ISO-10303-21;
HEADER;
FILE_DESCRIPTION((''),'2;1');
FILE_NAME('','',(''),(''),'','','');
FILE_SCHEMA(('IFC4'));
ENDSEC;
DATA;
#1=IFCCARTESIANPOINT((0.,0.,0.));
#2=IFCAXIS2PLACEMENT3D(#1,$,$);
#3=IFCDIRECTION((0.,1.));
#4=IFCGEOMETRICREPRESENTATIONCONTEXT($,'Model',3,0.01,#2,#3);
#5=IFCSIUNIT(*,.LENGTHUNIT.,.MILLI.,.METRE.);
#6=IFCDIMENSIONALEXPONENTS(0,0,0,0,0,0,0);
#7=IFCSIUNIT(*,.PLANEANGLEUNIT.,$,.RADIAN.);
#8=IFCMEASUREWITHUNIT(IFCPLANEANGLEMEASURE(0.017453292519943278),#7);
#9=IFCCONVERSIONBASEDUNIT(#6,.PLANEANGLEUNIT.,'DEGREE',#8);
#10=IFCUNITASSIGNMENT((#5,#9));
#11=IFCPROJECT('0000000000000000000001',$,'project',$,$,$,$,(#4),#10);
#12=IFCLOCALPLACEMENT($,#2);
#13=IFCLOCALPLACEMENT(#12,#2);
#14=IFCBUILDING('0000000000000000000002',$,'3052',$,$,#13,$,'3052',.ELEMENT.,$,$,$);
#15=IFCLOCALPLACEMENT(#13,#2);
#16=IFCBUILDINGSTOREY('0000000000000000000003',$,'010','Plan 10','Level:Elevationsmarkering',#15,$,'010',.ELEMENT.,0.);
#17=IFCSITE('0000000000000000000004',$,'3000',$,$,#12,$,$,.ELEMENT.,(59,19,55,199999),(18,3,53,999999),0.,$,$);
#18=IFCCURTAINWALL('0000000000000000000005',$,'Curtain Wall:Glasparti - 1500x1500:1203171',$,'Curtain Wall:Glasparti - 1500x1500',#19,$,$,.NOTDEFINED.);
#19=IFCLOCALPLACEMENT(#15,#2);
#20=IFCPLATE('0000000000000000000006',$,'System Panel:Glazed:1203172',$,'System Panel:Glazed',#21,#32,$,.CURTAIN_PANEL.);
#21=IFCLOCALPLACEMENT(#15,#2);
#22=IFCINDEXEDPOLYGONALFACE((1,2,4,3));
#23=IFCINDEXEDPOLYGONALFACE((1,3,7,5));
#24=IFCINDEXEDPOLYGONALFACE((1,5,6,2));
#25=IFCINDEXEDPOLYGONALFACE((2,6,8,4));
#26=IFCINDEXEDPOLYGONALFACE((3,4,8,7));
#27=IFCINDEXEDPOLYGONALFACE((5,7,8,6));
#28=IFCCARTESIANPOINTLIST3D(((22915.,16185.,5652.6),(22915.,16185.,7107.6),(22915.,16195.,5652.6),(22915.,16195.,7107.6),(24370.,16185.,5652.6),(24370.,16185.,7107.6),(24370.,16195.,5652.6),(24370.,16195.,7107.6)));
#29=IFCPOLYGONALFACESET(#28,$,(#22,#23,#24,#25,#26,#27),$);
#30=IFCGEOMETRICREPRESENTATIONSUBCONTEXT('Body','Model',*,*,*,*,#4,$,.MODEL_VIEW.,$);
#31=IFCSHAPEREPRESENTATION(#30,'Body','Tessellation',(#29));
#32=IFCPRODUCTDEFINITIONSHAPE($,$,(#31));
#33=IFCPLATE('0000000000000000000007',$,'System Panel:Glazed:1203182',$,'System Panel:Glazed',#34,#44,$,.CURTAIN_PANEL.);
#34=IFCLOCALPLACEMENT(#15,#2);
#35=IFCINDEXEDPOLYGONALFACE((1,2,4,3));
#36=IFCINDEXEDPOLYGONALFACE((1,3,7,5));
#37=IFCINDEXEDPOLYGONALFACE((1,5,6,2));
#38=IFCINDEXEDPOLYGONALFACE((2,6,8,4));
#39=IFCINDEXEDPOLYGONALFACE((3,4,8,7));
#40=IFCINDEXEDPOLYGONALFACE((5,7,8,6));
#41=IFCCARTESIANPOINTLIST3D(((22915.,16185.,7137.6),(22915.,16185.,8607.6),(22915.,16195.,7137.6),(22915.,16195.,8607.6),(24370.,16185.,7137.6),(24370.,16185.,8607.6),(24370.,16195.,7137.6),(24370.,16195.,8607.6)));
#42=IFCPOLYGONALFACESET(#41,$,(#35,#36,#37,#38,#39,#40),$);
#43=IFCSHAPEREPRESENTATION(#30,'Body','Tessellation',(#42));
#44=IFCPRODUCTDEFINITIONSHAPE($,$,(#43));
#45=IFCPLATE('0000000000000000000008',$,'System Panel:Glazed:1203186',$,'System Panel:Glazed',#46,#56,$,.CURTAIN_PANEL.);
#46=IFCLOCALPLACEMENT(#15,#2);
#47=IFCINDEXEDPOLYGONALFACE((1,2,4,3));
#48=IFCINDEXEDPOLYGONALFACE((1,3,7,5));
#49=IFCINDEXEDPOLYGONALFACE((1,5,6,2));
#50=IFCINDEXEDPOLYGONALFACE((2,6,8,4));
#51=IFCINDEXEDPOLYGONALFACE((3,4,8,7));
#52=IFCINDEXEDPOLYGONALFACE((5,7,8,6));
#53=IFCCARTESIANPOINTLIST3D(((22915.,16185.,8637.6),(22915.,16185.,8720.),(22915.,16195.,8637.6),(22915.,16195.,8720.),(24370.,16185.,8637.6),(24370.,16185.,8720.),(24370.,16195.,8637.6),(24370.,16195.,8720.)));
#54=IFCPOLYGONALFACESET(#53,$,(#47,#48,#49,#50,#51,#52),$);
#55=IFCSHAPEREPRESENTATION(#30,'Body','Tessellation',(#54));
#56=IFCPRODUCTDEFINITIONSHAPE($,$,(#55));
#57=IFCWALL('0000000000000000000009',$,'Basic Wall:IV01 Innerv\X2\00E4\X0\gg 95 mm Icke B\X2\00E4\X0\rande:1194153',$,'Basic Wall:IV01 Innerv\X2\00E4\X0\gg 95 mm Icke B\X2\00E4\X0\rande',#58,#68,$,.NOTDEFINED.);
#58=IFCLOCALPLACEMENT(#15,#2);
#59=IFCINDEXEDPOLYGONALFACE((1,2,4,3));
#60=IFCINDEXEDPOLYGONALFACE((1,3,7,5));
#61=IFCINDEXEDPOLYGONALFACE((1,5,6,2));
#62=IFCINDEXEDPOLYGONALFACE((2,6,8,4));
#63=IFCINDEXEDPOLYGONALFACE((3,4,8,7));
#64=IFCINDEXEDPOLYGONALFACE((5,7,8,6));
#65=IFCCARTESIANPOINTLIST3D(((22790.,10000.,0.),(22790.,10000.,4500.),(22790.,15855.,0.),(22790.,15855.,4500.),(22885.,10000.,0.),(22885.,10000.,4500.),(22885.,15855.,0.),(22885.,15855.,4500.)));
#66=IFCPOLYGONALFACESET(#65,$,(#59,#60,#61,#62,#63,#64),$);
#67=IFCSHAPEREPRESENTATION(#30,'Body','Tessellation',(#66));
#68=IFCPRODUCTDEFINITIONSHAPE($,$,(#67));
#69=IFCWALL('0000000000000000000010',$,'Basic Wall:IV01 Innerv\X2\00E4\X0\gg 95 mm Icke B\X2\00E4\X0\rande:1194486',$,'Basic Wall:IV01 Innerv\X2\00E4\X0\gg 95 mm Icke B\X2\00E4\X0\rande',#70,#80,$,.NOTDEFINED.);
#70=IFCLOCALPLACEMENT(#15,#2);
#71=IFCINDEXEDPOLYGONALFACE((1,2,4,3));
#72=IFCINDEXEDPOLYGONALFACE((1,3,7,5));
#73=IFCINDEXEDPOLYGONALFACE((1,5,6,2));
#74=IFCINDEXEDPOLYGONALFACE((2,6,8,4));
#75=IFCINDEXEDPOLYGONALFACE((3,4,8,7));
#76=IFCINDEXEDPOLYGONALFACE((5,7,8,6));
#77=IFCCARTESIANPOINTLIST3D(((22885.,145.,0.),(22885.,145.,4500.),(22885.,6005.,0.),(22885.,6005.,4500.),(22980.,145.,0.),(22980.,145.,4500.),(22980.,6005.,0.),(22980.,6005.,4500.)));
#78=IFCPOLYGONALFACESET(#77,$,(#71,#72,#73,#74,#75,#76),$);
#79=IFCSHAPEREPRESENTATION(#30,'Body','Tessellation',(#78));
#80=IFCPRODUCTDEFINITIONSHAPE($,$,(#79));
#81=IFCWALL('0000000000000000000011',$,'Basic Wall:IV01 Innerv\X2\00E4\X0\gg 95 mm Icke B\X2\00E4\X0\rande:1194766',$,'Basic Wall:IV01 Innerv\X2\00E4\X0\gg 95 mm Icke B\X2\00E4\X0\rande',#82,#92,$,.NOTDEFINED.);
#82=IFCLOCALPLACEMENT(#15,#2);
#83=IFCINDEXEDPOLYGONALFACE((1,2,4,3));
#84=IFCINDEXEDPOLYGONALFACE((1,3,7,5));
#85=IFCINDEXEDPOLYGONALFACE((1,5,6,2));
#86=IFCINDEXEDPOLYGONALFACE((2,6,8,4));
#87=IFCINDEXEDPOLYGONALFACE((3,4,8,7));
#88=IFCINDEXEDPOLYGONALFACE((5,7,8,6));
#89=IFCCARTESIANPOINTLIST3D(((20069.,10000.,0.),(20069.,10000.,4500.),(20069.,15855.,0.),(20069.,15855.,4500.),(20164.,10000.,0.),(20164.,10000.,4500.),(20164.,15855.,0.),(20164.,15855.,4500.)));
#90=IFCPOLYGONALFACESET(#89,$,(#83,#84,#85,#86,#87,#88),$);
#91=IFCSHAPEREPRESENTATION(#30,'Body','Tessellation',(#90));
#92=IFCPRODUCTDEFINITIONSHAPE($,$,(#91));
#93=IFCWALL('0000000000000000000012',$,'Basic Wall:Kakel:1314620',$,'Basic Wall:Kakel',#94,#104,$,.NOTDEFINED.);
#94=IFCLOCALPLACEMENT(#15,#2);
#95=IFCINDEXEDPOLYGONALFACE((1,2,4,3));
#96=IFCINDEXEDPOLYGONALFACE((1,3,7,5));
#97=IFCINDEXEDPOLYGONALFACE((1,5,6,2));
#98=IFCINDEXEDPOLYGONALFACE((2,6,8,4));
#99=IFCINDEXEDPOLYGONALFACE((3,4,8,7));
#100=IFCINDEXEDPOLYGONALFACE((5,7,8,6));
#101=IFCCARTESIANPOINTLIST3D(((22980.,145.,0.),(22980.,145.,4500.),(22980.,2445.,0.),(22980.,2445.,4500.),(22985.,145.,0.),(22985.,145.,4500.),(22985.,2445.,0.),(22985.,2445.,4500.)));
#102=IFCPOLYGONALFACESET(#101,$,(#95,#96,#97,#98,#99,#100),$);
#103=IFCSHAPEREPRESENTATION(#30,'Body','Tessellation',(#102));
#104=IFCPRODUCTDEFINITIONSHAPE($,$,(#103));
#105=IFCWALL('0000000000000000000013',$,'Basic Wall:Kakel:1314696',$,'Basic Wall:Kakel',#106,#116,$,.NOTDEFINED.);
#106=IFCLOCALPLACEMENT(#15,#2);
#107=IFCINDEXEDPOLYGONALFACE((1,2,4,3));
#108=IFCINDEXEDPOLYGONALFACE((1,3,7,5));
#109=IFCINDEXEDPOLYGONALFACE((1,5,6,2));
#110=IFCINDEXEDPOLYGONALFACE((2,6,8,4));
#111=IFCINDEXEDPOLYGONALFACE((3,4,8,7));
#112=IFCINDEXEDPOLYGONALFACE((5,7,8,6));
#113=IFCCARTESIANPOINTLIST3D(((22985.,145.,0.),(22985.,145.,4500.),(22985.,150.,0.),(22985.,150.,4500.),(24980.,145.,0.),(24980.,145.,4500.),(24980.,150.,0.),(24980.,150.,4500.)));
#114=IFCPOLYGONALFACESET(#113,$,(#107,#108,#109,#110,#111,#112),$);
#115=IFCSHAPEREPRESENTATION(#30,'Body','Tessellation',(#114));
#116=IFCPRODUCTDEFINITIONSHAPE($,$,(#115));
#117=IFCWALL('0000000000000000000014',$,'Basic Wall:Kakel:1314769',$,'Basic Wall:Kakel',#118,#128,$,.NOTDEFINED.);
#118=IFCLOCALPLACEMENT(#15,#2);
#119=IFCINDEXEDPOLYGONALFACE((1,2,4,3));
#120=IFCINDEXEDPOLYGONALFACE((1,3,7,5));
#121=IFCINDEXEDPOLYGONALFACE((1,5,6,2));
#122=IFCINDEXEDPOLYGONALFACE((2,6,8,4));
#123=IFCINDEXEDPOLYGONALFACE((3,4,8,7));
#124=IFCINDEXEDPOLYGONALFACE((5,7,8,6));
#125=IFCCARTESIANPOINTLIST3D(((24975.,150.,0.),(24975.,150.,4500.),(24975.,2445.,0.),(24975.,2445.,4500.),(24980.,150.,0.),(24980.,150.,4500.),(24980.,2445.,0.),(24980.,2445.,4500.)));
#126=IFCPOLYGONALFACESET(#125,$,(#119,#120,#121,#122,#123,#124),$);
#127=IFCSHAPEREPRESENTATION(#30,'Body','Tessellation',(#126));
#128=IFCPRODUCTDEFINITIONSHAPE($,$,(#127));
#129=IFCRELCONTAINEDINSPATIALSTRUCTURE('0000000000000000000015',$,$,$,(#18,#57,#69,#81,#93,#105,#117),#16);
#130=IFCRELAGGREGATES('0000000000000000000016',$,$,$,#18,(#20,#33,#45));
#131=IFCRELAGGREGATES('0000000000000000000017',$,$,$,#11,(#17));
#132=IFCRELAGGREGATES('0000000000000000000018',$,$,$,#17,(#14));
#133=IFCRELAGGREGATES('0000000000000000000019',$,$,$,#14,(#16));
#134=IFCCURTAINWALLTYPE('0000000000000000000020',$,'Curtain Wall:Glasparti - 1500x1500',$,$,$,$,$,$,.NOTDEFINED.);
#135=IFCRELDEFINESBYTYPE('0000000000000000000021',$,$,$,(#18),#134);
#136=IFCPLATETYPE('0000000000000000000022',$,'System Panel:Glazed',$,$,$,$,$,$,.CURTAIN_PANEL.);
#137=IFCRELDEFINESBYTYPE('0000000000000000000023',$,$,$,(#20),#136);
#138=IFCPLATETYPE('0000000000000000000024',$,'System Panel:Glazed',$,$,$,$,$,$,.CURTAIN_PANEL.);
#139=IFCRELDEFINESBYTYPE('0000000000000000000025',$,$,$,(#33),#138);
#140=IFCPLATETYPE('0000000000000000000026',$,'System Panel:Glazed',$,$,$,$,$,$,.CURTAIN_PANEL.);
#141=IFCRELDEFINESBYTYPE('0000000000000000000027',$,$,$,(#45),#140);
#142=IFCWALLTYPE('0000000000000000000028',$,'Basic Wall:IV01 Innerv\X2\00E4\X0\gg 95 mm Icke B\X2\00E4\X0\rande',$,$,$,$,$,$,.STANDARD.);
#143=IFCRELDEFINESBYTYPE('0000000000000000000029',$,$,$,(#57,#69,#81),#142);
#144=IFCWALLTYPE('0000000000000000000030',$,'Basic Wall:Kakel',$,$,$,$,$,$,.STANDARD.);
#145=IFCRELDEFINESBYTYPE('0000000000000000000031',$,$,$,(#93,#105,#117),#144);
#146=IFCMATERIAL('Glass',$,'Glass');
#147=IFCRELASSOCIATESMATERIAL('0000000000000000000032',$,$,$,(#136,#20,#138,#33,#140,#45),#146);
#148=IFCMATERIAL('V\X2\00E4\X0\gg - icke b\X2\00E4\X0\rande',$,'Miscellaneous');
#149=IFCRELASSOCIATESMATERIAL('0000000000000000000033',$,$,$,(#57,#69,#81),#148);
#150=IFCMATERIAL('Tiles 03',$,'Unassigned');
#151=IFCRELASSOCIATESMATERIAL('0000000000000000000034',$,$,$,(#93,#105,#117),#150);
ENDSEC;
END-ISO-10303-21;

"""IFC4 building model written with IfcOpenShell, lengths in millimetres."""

from ifc_helpers import new_model, entity, si_unit, converted_unit, direction, frame, origin, place, context, subcontext, project, spatial, indexed_curve, outline, extrude, source, transform, mapped, material, type_object, type_shapes, element, aggregate, save


model = new_model("IFC4")

# Units and contexts
model_context = context("Model", 3, precision=0.01, world=origin(), true_north=direction((0.0, 1.0)))
body_context = subcontext(model_context, "Body", "Model", "MODEL_VIEW")
ifc_project = project(units=[si_unit("LENGTHUNIT", "METRE", prefix="MILLI"), converted_unit("PLANEANGLEUNIT", "DEGREE", entity("IfcPlaneAngleMeasure", 0.017453292519943278), si_unit("PLANEANGLEUNIT", "RADIAN"), dimensions=[0, 0, 0, 0, 0, 0, 0])], contexts=[model_context])

# Site, building, storey
site_placement = place(None, origin())
site = spatial("IfcSite", under=ifc_project, at=site_placement, Name="3000", CompositionType="ELEMENT", RefLatitude=(59, 19, 55, 199999), RefLongitude=(18, 3, 53, 999999), RefElevation=0.0)
building_placement = place(site_placement, origin())
building = spatial("IfcBuilding", under=site, at=building_placement, Name="3052", LongName="3052", CompositionType="ELEMENT")
storey_placement = place(building_placement, origin())
storey = spatial("IfcBuildingStorey", under=building, at=storey_placement, Name="010", Description="Plan 10", ObjectType="Level:Elevationsmarkering", LongName="010", CompositionType="ELEMENT", Elevation=0.0)

# Curtain wall, plates
curtain_wall_type = type_object("IfcCurtainWallType", Name="Curtain Wall:Glasparti - 1500x1500", PredefinedType="NOTDEFINED")
curtain_wall_placement = place(storey_placement, origin())
curtain_wall = element("IfcCurtainWall", 1, at=curtain_wall_placement, inside=storey, type_object=curtain_wall_type, Name="Curtain Wall:Glasparti - 1500x1500:1203171", ObjectType="Curtain Wall:Glasparti - 1500x1500", PredefinedType="NOTDEFINED")
ifc_material_1 = material(Name="Glass", Category="Glass")
plate_type_1 = type_object("IfcPlateType", Name="System Panel:Glazed", PredefinedType="CURTAIN_PANEL", material=ifc_material_1)
shared_shape_1 = source(origin(), body_context, "Body", "SweptSolid", [
    extrude(outline(indexed_curve([(-5.0, -727.5), (5.0, -727.5), (5.0, 727.5), (-5.0, 727.5), (-5.0, -727.5)], self_intersect=False)), frame((0.0, 0.0, 0.0), z_axis=(0.0, 0.0, 1.0), x_axis=(0.0, 1.0, 0.0)), (0.0, 0.0, 1.0), 1455.0),
])
type_shapes(plate_type_1, [shared_shape_1])
plate_1_placement = place(curtain_wall_placement, frame((23642.5, 16190.0, 5652.6)))
plate_1 = element("IfcPlate", 2, at=plate_1_placement, type_object=plate_type_1, material=ifc_material_1, Name="System Panel:Glazed:1203172", ObjectType="System Panel:Glazed", PredefinedType="CURTAIN_PANEL", context=body_context, shape_type="MappedRepresentation", body=[
    mapped(shared_shape_1, transform((0.0, 0.0, 0.0), scale=1.0)),
])
plate_type_2 = type_object("IfcPlateType", Name="System Panel:Glazed", PredefinedType="CURTAIN_PANEL", material=ifc_material_1)
shared_shape_2 = source(origin(), body_context, "Body", "SweptSolid", [
    extrude(outline(indexed_curve([(-5.0, -727.5), (5.0, -727.5), (5.0, 727.5), (-5.0, 727.5), (-5.0, -727.5)], self_intersect=False)), frame((0.0, 0.0, 0.0), z_axis=(0.0, 0.0, 1.0), x_axis=(0.0, 1.0, 0.0)), (0.0, 0.0, 1.0), 1470.0),
])
type_shapes(plate_type_2, [shared_shape_2])
plate_2_placement = place(curtain_wall_placement, frame((23642.5, 16190.0, 7137.6)))
plate_2 = element("IfcPlate", 3, at=plate_2_placement, type_object=plate_type_2, material=ifc_material_1, Name="System Panel:Glazed:1203182", ObjectType="System Panel:Glazed", PredefinedType="CURTAIN_PANEL", context=body_context, shape_type="MappedRepresentation", body=[
    mapped(shared_shape_2, transform((0.0, 0.0, 0.0), scale=1.0)),
])
plate_type_3 = type_object("IfcPlateType", Name="System Panel:Glazed", PredefinedType="CURTAIN_PANEL", material=ifc_material_1)
shared_shape_3 = source(origin(), body_context, "Body", "SweptSolid", [
    extrude(outline(indexed_curve([(-5.0, -727.5), (5.0, -727.5), (5.0, 727.5), (-5.0, 727.5), (-5.0, -727.5)], self_intersect=False)), frame((0.0, 0.0, 0.0), z_axis=(0.0, 0.0, 1.0), x_axis=(0.0, 1.0, 0.0)), (0.0, 0.0, 1.0), 82.4),
])
type_shapes(plate_type_3, [shared_shape_3])
plate_3_placement = place(curtain_wall_placement, frame((23642.5, 16190.0, 8637.6)))
plate_3 = element("IfcPlate", 4, at=plate_3_placement, type_object=plate_type_3, material=ifc_material_1, Name="System Panel:Glazed:1203186", ObjectType="System Panel:Glazed", PredefinedType="CURTAIN_PANEL", context=body_context, shape_type="MappedRepresentation", body=[
    mapped(shared_shape_3, transform((0.0, 0.0, 0.0), scale=1.0)),
])
aggregate(curtain_wall, [plate_1, plate_2, plate_3])

# Walls
ifc_material_2 = material(Name="Vägg - icke bärande", Category="Miscellaneous")
wall_type_1 = type_object("IfcWallType", Name="Basic Wall:IV01 Innervägg 95 mm Icke Bärande", PredefinedType="STANDARD")
wall_1_placement = place(storey_placement, frame((22837.5, 10000.0, 0.0), z_axis=(0.0, 0.0, 1.0), x_axis=(0.0, 1.0, 0.0)))
element("IfcWall", 5, at=wall_1_placement, inside=storey, type_object=wall_type_1, material=ifc_material_2, Name="Basic Wall:IV01 Innervägg 95 mm Icke Bärande:1194153", ObjectType="Basic Wall:IV01 Innervägg 95 mm Icke Bärande", PredefinedType="NOTDEFINED", context=body_context, shape_type="SweptSolid", body=[
    extrude(outline(indexed_curve([(5855.0, 47.5), (0.0, 47.5), (0.0, -47.5), (5855.0, -47.5), (5855.0, 47.5)], self_intersect=False)), origin(), (0.0, 0.0, 1.0), 4500.0),
])
wall_2_placement = place(storey_placement, frame((22932.5, 6005.0, 0.0), z_axis=(0.0, 0.0, 1.0), x_axis=(0.0, -1.0, 0.0)))
element("IfcWall", 6, at=wall_2_placement, inside=storey, type_object=wall_type_1, material=ifc_material_2, Name="Basic Wall:IV01 Innervägg 95 mm Icke Bärande:1194486", ObjectType="Basic Wall:IV01 Innervägg 95 mm Icke Bärande", PredefinedType="NOTDEFINED", context=body_context, shape_type="SweptSolid", body=[
    extrude(outline(indexed_curve([(5860.0, 47.5), (0.0, 47.5), (0.0, -47.5), (5860.0, -47.5), (5860.0, 47.5)], self_intersect=False)), origin(), (0.0, 0.0, 1.0), 4500.0),
])
wall_3_placement = place(storey_placement, frame((20116.5, 15855.0, 0.0), z_axis=(0.0, 0.0, 1.0), x_axis=(0.0, -1.0, 0.0)))
element("IfcWall", 7, at=wall_3_placement, inside=storey, type_object=wall_type_1, material=ifc_material_2, Name="Basic Wall:IV01 Innervägg 95 mm Icke Bärande:1194766", ObjectType="Basic Wall:IV01 Innervägg 95 mm Icke Bärande", PredefinedType="NOTDEFINED", context=body_context, shape_type="SweptSolid", body=[
    extrude(outline(indexed_curve([(5855.0, 47.5), (0.0, 47.5), (0.0, -47.5), (5855.0, -47.5), (5855.0, 47.5)], self_intersect=False)), origin(), (0.0, 0.0, 1.0), 4500.0),
])
ifc_material_3 = material(Name="Tiles 03", Category="Unassigned")
wall_type_2 = type_object("IfcWallType", Name="Basic Wall:Kakel", PredefinedType="STANDARD")
wall_4_placement = place(storey_placement, frame((22982.5, 2445.0, 0.0), z_axis=(0.0, 0.0, 1.0), x_axis=(0.0, -1.0, 0.0)))
element("IfcWall", 8, at=wall_4_placement, inside=storey, type_object=wall_type_2, material=ifc_material_3, Name="Basic Wall:Kakel:1314620", ObjectType="Basic Wall:Kakel", PredefinedType="NOTDEFINED", context=body_context, shape_type="SweptSolid", body=[
    extrude(outline(indexed_curve([(2300.0, 2.5), (0.0, 2.5), (0.0, -2.5), (2300.0, -2.5), (2300.0, 2.5)], self_intersect=False)), origin(), (0.0, 0.0, 1.0), 4500.0),
])
wall_5_placement = place(storey_placement, frame((22985.0, 147.5, 0.0)))
element("IfcWall", 9, at=wall_5_placement, inside=storey, type_object=wall_type_2, material=ifc_material_3, Name="Basic Wall:Kakel:1314696", ObjectType="Basic Wall:Kakel", PredefinedType="NOTDEFINED", context=body_context, shape_type="SweptSolid", body=[
    extrude(outline(indexed_curve([(1995.0, 2.5), (0.0, 2.5), (0.0, -2.5), (1995.0, -2.5), (1995.0, 2.5)], self_intersect=False)), origin(), (0.0, 0.0, 1.0), 4500.0),
])
wall_6_placement = place(storey_placement, frame((24977.5, 150.0, 0.0), z_axis=(0.0, 0.0, 1.0), x_axis=(0.0, 1.0, 0.0)))
element("IfcWall", 10, at=wall_6_placement, inside=storey, type_object=wall_type_2, material=ifc_material_3, Name="Basic Wall:Kakel:1314769", ObjectType="Basic Wall:Kakel", PredefinedType="NOTDEFINED", context=body_context, shape_type="SweptSolid", body=[
    extrude(outline(indexed_curve([(2295.0, 2.5), (0.0, 2.5), (0.0, -2.5), (2295.0, -2.5), (2295.0, 2.5)], self_intersect=False)), origin(), (0.0, 0.0, 1.0), 4500.0),
])

save(model, "model.ifc")
